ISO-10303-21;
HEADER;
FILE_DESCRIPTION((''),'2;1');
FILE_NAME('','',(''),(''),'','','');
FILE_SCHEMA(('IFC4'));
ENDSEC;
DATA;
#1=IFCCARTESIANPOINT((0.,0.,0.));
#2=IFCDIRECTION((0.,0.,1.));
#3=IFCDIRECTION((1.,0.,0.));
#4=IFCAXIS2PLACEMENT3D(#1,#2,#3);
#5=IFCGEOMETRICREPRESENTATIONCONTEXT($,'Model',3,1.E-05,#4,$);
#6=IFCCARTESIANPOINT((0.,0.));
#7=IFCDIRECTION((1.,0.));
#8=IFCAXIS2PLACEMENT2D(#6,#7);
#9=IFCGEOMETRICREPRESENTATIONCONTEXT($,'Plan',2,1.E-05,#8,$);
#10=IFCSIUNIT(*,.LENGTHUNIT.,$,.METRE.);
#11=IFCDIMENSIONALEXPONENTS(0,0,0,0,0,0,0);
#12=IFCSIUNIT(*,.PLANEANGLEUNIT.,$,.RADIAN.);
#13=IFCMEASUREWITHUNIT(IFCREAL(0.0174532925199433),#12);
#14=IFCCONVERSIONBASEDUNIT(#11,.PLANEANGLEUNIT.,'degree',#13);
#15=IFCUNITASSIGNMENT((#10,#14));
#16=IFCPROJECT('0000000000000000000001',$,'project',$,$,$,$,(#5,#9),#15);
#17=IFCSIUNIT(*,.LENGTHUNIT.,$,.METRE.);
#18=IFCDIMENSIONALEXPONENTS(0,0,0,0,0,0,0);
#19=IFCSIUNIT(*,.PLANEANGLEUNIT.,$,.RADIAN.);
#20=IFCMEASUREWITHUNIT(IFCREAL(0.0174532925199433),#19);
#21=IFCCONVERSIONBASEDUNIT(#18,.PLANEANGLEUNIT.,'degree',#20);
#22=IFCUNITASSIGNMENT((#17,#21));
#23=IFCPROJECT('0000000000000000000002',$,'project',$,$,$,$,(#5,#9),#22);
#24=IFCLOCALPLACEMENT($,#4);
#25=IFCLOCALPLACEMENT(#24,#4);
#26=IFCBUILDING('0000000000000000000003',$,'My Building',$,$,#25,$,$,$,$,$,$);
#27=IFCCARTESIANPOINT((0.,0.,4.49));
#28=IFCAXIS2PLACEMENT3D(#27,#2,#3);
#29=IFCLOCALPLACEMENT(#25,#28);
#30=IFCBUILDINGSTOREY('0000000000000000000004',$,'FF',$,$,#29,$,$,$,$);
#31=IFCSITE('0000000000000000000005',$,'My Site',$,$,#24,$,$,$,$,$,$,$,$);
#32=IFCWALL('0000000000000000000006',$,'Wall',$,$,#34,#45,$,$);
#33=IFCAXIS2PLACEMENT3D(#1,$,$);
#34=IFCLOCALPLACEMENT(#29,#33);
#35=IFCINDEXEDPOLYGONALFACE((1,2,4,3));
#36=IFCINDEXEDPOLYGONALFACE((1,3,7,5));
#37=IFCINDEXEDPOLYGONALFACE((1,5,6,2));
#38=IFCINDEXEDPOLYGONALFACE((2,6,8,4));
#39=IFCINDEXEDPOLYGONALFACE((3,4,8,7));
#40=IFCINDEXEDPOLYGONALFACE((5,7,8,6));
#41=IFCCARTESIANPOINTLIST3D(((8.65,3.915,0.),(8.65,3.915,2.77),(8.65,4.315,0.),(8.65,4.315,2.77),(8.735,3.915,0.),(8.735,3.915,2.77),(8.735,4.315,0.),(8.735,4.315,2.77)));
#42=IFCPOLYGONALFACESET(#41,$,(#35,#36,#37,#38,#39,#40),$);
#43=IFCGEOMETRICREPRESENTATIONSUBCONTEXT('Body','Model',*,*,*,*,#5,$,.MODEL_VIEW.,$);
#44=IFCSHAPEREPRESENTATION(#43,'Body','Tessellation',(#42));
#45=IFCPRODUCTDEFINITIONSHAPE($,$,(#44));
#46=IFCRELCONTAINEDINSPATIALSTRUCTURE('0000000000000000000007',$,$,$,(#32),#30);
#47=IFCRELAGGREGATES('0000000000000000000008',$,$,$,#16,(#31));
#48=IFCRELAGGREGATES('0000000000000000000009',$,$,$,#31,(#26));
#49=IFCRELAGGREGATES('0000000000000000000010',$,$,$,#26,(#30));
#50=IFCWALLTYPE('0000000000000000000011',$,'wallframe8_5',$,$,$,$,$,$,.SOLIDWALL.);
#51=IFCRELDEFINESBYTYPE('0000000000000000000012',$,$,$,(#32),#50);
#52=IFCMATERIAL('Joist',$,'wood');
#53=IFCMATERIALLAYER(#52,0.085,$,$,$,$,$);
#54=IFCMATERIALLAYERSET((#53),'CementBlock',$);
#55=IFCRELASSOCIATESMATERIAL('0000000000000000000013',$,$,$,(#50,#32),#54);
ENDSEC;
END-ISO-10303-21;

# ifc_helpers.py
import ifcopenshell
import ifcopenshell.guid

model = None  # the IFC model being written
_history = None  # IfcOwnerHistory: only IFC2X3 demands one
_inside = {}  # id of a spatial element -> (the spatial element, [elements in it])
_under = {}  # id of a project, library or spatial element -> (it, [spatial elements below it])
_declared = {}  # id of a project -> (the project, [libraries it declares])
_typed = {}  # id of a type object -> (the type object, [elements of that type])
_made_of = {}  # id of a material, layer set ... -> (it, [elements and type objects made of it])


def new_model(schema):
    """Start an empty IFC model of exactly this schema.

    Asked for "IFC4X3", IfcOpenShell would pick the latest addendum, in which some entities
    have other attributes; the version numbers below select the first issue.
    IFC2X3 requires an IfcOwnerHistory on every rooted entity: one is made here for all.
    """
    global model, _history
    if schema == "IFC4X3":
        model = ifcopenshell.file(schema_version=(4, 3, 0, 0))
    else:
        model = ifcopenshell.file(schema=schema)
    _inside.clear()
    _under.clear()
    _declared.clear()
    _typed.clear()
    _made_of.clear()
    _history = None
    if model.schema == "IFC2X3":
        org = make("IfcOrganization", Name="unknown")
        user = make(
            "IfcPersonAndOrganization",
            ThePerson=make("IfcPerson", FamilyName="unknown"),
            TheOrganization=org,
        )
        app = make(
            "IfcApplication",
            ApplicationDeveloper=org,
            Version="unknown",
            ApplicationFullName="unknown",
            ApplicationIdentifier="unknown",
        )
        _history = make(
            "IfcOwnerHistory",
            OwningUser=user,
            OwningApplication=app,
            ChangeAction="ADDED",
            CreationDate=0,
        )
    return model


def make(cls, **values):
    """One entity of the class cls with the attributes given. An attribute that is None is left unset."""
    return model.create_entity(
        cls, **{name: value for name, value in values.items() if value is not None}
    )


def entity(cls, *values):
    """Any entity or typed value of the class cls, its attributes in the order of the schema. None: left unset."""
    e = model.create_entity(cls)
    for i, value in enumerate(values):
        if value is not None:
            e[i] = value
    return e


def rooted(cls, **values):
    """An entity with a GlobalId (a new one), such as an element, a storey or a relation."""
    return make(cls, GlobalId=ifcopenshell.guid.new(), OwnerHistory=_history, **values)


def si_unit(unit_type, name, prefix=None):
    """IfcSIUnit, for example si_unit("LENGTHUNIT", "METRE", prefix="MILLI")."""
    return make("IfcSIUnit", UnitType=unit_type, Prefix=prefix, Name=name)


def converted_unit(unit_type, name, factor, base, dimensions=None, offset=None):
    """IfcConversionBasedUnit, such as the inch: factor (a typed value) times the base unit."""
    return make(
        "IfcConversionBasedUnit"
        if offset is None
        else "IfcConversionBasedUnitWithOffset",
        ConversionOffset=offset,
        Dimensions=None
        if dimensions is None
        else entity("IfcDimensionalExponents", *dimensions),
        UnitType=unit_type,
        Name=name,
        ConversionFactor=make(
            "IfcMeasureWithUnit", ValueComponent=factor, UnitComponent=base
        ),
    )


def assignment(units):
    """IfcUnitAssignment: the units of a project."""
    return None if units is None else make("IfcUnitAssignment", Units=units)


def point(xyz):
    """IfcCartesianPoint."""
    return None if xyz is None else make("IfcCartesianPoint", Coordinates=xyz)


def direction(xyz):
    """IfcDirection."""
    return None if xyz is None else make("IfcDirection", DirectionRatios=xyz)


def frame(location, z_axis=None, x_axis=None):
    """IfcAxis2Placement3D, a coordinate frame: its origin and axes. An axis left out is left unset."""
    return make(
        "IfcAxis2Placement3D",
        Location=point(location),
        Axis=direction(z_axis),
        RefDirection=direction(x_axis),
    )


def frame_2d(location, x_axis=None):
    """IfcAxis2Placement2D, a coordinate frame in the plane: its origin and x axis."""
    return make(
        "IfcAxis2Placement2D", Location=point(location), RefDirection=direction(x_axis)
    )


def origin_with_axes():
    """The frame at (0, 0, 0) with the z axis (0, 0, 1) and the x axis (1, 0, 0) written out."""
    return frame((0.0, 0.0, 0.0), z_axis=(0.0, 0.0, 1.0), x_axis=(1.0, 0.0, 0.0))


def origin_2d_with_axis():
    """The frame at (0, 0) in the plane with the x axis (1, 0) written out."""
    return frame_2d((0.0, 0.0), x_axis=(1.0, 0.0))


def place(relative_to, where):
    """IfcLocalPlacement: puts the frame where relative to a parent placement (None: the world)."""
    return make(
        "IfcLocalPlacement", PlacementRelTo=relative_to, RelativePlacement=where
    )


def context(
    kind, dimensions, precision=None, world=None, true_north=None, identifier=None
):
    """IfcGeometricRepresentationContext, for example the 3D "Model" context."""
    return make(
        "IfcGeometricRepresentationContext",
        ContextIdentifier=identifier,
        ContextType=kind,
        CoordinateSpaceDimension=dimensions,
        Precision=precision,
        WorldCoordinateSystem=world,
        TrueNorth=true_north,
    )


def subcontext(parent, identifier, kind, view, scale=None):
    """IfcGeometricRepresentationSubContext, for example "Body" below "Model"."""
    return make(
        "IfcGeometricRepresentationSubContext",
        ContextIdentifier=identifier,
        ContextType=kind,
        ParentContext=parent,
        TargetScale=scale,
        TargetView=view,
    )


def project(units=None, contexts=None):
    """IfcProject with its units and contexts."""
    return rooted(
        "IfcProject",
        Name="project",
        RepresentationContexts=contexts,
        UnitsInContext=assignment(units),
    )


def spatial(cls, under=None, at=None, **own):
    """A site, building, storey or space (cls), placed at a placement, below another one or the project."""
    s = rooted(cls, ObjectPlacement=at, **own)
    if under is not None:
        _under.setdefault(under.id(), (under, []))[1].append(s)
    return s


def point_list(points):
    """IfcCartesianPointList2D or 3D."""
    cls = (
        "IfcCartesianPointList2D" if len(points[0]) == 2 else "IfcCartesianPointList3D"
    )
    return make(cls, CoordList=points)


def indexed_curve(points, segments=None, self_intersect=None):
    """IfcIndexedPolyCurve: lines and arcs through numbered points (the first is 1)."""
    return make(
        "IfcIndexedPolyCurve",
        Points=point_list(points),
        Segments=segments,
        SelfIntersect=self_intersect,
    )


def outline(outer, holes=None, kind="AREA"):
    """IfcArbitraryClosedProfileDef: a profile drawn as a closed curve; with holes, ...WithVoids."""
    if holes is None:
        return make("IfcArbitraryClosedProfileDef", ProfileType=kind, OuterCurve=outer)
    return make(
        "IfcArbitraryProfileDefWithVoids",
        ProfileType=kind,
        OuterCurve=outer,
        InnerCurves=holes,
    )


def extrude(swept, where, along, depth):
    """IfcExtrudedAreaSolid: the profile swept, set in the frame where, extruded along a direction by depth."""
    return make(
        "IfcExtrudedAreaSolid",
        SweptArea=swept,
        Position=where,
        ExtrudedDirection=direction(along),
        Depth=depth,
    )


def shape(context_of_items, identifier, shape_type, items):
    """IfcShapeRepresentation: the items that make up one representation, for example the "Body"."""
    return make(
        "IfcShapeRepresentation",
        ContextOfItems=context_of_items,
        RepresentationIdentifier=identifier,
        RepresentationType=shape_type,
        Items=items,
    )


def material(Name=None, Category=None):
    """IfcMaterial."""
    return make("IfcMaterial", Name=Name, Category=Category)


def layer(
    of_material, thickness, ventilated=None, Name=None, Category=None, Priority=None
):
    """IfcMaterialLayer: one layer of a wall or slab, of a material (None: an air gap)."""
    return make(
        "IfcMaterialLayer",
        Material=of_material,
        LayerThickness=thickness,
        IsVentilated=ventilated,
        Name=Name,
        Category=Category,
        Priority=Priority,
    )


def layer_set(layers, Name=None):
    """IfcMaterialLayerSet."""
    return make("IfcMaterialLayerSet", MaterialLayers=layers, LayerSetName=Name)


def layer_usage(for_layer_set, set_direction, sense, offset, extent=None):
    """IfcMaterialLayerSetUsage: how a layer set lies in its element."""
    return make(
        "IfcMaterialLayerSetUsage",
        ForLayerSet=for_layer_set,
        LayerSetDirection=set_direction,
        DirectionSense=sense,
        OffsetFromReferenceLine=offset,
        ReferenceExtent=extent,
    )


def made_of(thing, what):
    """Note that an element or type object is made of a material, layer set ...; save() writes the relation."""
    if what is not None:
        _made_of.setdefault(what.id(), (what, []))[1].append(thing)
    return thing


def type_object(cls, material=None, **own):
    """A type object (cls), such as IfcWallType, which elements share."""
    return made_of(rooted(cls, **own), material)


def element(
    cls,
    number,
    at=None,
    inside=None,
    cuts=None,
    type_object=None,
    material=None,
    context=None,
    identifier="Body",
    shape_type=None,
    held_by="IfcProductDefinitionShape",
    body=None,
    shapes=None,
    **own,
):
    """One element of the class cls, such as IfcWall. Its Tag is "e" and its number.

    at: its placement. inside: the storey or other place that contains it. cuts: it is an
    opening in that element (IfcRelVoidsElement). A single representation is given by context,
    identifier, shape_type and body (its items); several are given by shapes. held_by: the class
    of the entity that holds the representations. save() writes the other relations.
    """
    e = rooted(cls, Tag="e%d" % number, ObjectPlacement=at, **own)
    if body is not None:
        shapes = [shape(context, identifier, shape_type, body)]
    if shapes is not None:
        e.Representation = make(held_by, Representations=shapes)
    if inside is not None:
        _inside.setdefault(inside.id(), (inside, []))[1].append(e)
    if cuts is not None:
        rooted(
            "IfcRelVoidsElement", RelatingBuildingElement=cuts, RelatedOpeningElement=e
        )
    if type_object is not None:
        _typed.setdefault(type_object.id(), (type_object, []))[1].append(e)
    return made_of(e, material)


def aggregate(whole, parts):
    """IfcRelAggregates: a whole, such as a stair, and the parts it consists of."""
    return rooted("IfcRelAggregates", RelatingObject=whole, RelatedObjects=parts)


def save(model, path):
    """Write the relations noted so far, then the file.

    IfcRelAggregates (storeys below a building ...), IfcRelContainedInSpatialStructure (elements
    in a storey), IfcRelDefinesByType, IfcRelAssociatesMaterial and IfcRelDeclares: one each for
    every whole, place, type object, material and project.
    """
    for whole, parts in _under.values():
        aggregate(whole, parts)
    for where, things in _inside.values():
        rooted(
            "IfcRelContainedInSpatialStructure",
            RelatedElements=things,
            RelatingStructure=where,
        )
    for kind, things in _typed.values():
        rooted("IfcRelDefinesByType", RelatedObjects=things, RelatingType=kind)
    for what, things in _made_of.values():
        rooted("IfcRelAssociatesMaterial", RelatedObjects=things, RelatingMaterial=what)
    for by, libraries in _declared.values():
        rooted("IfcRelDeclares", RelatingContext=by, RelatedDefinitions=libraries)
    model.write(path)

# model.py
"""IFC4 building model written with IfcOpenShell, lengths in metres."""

from ifc_helpers import new_model, entity, si_unit, converted_unit, frame, origin_with_axes, origin_2d_with_axis, place, context, subcontext, project, spatial, indexed_curve, outline, extrude, material, layer, layer_set, layer_usage, type_object, element, save


model = new_model("IFC4")

# Units and contexts
model_context = context("Model", 3, precision=1e-05, world=origin_with_axes())
plan_context = context("Plan", 2, precision=1e-05, world=origin_2d_with_axis())
body_context = subcontext(model_context, "Body", "Model", "MODEL_VIEW")
ifc_project_1 = project(units=[si_unit("LENGTHUNIT", "METRE"), converted_unit("PLANEANGLEUNIT", "degree", entity("IfcReal", 0.0174532925199433), si_unit("PLANEANGLEUNIT", "RADIAN"), dimensions=[0, 0, 0, 0, 0, 0, 0])], contexts=[model_context, plan_context])
ifc_project_2 = project(units=[si_unit("LENGTHUNIT", "METRE"), converted_unit("PLANEANGLEUNIT", "degree", entity("IfcReal", 0.0174532925199433), si_unit("PLANEANGLEUNIT", "RADIAN"), dimensions=[0, 0, 0, 0, 0, 0, 0])], contexts=[model_context, plan_context])

# Site, building, storey
site_placement = place(None, origin_with_axes())
site = spatial("IfcSite", under=ifc_project_1, at=site_placement, Name="My Site")
building_placement = place(site_placement, origin_with_axes())
building = spatial("IfcBuilding", under=site, at=building_placement, Name="My Building")
storey_placement = place(building_placement, frame((0.0, 0.0, 4.49), z_axis=(0.0, 0.0, 1.0), x_axis=(1.0, 0.0, 0.0)))
storey = spatial("IfcBuildingStorey", under=building, at=storey_placement, Name="FF")

# Wall
ifc_material_1 = material(Name="Joist", Category="wood")
ifc_layer_1 = layer(ifc_material_1, 0.085)
ifc_layer_set_1 = layer_set([ifc_layer_1], Name="CementBlock")
wall_type = type_object("IfcWallType", Name="wallframe8_5", PredefinedType="SOLIDWALL", material=ifc_layer_set_1)
ifc_layer_usage_1 = layer_usage(ifc_layer_set_1, "AXIS2", "POSITIVE", 0.0)
wall_1_placement = place(storey_placement, frame((8.65, 4.315, 0.0), z_axis=(0.0, 0.0, 1.0), x_axis=(-0.000001, -1.0, 0.0)))
element("IfcWall", 1, at=wall_1_placement, inside=storey, type_object=wall_type, material=ifc_layer_usage_1, Name="Wall", context=body_context, shape_type="SweptSolid", body=[
    extrude(outline(indexed_curve([(0.0, 0.0), (0.0, 0.085), (0.4, 0.085), (0.4, 0.0), (0.0, 0.0)], self_intersect=False)), origin_with_axes(), (0.0, 0.0, 1.0), 2.77),
])

save(model, "model.ifc")
